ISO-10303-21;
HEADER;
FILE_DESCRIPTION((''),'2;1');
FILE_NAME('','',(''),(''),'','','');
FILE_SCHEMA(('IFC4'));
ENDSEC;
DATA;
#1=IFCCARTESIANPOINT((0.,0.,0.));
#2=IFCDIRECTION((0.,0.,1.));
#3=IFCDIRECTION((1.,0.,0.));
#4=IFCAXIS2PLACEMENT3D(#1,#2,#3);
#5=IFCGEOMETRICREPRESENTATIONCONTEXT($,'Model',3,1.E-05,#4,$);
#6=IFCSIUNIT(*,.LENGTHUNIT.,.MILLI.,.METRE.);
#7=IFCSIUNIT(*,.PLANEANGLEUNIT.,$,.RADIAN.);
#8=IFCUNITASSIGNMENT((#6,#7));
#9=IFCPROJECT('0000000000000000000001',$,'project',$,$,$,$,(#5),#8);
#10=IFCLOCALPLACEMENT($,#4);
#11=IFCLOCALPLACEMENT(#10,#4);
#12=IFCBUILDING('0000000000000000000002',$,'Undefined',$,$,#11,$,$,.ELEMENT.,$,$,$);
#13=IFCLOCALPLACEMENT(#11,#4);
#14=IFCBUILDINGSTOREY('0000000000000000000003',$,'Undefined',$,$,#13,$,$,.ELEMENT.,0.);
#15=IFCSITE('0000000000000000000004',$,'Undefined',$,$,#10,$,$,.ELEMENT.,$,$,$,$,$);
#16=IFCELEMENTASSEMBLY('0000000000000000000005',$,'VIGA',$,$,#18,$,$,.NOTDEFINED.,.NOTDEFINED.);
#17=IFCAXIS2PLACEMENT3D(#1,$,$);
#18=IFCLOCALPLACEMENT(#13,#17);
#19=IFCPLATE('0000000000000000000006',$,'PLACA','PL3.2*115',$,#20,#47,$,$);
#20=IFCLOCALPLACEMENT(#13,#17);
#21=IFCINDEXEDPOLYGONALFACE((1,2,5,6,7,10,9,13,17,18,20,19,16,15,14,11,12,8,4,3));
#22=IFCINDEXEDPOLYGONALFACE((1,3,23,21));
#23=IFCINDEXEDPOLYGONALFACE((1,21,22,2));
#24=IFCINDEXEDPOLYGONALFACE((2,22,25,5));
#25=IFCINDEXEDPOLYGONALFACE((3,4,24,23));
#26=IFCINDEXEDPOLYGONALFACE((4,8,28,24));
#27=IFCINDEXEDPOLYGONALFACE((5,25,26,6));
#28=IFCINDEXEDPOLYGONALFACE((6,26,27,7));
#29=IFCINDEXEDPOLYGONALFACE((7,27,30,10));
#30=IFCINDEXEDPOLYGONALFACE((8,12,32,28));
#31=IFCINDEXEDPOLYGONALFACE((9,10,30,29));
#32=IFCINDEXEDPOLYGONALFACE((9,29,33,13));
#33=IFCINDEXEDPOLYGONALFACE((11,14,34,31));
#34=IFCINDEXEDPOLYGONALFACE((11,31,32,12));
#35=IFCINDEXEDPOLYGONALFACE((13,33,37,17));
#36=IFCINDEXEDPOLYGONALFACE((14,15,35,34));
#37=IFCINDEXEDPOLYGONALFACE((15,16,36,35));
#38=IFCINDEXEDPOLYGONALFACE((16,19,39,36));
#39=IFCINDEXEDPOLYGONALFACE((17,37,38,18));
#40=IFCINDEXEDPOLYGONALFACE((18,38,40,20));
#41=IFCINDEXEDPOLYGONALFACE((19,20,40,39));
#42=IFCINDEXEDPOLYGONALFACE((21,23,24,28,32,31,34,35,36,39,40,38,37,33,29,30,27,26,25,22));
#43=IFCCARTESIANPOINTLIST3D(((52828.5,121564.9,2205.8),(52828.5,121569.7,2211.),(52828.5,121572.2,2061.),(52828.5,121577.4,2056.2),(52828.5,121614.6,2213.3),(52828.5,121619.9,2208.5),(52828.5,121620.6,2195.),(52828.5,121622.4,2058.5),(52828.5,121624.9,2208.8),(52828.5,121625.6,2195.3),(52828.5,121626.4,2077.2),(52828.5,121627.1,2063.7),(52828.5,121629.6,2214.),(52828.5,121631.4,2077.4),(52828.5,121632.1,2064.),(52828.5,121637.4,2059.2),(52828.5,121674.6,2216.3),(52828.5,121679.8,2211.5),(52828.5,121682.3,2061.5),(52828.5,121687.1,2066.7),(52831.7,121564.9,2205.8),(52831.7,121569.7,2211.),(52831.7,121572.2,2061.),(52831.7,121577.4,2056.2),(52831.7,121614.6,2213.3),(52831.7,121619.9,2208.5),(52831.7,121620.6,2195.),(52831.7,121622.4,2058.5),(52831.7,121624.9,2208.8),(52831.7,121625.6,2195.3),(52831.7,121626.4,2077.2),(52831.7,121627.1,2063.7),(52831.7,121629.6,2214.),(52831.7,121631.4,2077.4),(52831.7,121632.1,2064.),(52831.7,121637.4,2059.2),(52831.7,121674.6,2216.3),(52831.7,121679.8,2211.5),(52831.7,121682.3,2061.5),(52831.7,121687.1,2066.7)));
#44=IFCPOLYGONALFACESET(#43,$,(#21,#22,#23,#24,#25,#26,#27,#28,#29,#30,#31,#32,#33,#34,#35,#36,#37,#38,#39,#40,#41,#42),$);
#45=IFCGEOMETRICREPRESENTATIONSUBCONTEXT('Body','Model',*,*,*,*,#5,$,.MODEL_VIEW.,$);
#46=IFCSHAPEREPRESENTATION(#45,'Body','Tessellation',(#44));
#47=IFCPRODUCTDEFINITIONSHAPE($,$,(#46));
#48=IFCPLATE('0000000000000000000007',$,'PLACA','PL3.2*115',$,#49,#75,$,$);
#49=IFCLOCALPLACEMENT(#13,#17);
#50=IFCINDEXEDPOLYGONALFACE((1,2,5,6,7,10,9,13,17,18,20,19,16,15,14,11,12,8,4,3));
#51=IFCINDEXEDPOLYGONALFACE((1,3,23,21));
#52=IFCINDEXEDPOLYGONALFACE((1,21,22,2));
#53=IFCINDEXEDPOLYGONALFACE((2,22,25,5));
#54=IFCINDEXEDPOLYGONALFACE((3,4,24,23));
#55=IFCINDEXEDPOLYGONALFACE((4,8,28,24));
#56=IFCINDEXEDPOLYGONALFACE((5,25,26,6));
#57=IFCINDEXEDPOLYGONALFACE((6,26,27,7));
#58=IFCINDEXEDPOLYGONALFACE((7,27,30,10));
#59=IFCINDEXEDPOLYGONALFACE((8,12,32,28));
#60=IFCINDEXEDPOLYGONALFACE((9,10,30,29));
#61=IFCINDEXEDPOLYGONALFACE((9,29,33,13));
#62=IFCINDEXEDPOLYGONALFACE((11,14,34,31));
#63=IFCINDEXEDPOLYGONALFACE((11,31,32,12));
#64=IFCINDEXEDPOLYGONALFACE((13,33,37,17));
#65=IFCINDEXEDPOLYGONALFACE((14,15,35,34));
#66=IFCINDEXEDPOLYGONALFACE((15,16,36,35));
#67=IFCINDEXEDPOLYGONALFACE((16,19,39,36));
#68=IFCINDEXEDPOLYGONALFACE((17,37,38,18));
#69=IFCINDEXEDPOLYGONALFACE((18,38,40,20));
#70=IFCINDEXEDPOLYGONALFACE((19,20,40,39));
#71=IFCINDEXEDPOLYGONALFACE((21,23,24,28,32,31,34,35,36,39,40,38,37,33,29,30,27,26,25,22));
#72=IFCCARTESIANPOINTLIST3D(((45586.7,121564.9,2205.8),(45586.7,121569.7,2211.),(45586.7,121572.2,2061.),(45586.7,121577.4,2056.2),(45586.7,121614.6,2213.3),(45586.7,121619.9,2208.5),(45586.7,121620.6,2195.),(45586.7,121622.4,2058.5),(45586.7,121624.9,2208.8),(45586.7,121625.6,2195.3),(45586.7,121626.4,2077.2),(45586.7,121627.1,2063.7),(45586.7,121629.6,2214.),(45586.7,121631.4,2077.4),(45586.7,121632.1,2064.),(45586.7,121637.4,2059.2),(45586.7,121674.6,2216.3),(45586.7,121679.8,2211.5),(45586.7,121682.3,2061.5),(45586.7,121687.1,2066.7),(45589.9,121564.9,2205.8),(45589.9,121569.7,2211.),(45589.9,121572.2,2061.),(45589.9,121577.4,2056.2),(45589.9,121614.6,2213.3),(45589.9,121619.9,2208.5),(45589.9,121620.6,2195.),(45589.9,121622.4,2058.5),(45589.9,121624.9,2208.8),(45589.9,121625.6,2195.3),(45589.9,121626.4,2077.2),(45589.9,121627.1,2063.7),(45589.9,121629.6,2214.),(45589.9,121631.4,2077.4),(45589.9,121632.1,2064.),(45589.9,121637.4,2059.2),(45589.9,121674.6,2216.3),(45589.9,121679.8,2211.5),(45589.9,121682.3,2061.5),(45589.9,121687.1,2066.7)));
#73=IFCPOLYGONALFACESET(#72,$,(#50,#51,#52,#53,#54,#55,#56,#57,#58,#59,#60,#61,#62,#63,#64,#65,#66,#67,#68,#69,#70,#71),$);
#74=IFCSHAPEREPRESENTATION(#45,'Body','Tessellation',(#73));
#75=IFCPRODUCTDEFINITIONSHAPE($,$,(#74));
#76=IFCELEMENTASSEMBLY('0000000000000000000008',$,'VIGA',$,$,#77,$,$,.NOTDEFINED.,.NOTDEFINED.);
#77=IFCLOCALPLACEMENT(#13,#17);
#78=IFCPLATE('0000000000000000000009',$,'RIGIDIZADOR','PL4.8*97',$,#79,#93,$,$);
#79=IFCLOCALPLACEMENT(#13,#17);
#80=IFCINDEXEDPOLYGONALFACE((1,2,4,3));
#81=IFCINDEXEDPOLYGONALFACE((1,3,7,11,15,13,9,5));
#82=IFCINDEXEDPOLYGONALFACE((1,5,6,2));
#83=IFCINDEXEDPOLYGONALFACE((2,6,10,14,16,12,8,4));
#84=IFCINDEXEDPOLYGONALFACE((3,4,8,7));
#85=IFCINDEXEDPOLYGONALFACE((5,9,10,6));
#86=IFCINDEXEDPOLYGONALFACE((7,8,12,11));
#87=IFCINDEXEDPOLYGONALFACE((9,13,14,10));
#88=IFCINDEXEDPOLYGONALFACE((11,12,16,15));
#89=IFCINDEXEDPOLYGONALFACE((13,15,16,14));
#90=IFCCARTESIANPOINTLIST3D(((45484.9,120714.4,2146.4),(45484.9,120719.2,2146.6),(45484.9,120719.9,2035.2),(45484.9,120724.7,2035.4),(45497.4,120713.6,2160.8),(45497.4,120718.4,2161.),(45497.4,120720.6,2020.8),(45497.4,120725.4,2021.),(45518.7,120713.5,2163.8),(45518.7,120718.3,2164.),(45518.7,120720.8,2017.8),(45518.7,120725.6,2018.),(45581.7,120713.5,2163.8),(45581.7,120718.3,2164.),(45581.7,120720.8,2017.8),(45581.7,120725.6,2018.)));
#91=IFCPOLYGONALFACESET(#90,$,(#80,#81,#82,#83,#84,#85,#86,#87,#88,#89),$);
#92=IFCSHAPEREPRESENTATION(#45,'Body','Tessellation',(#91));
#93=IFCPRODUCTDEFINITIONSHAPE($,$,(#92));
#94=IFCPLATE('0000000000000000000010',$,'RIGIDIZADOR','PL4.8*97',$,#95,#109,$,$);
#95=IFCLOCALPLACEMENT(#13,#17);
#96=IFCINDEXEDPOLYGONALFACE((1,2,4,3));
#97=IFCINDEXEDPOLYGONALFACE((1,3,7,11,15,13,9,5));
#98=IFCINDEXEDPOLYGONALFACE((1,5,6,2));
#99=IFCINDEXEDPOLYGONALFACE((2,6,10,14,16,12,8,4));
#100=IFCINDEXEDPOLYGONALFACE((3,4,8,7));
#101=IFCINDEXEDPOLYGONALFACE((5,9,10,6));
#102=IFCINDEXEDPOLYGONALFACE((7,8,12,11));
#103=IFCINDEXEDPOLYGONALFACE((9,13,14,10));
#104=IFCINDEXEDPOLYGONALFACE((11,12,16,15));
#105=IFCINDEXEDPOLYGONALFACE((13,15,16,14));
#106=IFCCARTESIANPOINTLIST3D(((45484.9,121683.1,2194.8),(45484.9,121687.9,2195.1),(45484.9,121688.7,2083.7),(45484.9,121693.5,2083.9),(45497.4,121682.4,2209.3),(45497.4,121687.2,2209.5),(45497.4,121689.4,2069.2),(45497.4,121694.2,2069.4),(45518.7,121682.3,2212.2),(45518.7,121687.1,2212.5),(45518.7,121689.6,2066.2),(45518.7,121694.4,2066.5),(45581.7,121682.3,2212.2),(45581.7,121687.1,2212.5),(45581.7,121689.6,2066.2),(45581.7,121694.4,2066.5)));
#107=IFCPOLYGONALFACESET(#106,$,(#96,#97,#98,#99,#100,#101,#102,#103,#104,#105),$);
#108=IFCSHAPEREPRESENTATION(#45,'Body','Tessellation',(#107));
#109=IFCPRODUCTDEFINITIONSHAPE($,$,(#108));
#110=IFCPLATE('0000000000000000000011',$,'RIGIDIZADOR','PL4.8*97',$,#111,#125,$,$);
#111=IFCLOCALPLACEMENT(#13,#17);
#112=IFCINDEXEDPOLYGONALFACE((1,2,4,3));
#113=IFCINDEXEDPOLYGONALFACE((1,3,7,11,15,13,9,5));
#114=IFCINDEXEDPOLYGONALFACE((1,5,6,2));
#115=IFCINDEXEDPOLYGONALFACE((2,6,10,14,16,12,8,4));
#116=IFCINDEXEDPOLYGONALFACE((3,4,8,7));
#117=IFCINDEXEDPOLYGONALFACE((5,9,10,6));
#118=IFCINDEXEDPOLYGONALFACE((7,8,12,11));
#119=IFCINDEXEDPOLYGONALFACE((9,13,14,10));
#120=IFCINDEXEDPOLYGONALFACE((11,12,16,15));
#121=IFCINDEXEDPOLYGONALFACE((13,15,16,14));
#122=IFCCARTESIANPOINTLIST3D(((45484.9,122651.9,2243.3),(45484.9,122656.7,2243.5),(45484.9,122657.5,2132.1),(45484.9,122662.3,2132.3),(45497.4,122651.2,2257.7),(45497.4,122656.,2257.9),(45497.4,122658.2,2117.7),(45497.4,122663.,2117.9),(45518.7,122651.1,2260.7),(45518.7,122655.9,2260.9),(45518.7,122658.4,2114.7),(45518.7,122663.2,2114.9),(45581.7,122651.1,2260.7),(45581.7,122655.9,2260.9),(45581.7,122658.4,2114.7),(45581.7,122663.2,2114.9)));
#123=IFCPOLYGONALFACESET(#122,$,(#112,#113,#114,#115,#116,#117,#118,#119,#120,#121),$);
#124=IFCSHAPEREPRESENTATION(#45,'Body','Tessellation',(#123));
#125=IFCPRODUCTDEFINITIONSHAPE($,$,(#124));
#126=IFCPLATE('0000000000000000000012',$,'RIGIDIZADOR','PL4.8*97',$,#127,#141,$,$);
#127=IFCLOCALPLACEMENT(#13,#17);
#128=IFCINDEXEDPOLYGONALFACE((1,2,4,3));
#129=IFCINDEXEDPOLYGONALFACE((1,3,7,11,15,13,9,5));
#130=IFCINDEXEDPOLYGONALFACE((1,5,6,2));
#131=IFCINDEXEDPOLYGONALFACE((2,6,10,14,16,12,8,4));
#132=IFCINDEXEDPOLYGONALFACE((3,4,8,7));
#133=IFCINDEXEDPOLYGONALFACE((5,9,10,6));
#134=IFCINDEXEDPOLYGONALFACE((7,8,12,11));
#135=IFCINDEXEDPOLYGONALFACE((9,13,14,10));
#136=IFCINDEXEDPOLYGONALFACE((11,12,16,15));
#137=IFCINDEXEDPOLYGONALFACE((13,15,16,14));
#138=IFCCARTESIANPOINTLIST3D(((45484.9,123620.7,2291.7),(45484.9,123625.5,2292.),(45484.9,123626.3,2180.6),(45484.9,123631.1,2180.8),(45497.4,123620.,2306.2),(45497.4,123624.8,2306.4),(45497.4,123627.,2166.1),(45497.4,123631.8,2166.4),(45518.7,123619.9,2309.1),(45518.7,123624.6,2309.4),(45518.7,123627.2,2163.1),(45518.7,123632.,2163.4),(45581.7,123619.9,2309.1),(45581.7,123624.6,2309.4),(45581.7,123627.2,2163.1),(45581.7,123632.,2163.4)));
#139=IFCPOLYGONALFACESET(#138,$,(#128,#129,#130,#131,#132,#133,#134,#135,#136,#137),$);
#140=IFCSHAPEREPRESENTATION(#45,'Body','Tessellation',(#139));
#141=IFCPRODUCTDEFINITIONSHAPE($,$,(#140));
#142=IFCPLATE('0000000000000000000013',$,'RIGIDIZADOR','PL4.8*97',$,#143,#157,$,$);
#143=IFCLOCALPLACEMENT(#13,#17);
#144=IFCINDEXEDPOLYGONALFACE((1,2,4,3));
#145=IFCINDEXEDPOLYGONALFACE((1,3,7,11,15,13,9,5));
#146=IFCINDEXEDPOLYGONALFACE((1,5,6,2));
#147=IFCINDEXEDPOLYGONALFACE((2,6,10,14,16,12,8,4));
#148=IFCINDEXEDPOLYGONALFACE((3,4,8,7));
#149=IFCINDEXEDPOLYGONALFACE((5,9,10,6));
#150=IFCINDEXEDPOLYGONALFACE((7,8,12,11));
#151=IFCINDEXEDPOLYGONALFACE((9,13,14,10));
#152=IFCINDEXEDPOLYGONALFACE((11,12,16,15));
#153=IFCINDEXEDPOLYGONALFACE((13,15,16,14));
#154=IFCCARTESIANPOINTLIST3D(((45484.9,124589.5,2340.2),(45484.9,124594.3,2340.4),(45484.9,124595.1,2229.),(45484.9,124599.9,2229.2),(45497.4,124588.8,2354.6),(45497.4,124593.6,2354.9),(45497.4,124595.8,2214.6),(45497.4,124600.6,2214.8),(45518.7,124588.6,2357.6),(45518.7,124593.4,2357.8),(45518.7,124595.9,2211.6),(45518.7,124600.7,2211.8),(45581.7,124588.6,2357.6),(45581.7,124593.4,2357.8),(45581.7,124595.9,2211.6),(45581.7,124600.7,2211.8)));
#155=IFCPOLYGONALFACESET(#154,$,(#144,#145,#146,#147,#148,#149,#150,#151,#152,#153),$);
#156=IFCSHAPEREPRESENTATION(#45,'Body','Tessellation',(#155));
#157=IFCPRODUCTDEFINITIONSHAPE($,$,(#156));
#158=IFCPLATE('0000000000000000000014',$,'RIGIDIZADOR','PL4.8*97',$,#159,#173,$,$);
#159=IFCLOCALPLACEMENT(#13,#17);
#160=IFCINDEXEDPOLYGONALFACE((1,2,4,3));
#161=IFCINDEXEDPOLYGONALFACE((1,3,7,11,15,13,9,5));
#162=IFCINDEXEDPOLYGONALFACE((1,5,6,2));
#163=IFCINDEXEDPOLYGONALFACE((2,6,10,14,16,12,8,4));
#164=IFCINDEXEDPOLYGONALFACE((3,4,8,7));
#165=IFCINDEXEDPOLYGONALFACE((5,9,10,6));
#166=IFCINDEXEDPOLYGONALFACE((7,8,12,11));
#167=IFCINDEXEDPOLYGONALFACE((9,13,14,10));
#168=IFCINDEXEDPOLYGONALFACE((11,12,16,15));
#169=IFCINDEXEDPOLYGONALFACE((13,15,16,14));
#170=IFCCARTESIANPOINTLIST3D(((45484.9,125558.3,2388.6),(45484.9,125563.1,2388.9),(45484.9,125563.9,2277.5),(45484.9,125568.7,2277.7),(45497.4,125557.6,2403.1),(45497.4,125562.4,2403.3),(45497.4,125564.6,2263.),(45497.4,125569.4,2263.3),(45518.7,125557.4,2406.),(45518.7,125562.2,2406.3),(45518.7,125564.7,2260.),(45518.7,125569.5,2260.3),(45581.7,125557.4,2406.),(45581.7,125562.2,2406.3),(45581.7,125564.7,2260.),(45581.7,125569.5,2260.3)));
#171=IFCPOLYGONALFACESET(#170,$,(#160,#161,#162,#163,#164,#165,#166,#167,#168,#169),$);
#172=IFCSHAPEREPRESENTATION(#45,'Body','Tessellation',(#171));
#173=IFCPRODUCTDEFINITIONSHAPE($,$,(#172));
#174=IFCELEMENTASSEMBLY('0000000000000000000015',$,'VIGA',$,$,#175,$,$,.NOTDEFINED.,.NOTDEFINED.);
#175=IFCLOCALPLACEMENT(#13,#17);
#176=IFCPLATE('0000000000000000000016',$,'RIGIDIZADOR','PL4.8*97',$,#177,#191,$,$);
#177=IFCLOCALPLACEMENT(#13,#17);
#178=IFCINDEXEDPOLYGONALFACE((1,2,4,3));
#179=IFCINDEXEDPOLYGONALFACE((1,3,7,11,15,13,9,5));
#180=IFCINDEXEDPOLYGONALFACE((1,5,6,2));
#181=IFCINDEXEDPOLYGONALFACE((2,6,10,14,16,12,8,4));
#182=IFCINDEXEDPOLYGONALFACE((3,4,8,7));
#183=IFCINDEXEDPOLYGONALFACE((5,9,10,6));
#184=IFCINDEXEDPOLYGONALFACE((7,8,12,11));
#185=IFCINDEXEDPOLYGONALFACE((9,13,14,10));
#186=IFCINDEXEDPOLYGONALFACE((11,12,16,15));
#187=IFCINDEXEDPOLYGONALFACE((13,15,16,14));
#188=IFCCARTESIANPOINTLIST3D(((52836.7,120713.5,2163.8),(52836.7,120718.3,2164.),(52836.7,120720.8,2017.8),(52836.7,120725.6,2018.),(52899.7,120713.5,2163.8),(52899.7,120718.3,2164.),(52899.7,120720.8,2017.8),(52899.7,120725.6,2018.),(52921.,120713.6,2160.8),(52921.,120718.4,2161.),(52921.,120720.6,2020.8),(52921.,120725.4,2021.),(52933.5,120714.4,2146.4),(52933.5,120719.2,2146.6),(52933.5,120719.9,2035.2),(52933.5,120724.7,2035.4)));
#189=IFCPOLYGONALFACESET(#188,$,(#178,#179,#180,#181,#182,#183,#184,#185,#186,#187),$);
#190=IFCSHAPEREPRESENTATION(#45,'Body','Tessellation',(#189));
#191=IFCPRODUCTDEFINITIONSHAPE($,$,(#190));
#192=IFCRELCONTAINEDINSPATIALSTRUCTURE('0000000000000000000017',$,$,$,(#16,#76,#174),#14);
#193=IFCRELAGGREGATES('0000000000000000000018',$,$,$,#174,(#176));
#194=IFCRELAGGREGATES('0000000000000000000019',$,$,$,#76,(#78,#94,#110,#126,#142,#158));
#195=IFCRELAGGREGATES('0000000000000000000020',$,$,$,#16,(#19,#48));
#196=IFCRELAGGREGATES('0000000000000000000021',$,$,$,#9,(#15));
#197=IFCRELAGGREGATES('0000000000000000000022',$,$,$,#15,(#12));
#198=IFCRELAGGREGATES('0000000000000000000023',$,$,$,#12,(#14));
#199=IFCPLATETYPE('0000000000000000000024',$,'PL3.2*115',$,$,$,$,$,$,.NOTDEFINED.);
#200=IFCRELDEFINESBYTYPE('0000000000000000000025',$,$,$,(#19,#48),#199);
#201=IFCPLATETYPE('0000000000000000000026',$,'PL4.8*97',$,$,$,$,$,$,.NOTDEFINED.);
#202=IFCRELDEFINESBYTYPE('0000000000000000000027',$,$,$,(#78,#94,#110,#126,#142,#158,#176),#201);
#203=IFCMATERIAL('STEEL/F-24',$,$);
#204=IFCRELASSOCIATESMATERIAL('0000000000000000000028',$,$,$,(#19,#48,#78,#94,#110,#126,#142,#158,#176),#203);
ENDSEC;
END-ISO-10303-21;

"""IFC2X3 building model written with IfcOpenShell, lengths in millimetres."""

from ifc_helpers import new_model, si_unit, frame, origin_with_axes, place, context, subcontext, project, spatial, polyline, outline, extrude, material, type_object, element, aggregate, save


model = new_model("IFC2X3")

# Units and contexts
model_context = context("Model", 3, precision=1e-05, world=origin_with_axes())
body_context = subcontext(model_context, "Body", "Model", "MODEL_VIEW")
ifc_project = project(units=[si_unit("LENGTHUNIT", "METRE", prefix="MILLI"), si_unit("PLANEANGLEUNIT", "RADIAN")], contexts=[model_context])

# Site, building, storey
site_placement = place(None, origin_with_axes())
site = spatial("IfcSite", under=ifc_project, at=site_placement, Name="Undefined", CompositionType="ELEMENT")
building_placement = place(site_placement, origin_with_axes())
building = spatial("IfcBuilding", under=site, at=building_placement, Name="Undefined", CompositionType="ELEMENT")
storey_placement = place(building_placement, origin_with_axes())
storey = spatial("IfcBuildingStorey", under=building, at=storey_placement, Name="Undefined", CompositionType="ELEMENT", Elevation=0.0)

# Element assemblies, plates
ifc_material_1 = material(Name="STEEL/F-24")
plate_type_1 = type_object("IfcPlateType", Name="PL3.2*115", PredefinedType="NOTDEFINED")
assembly_1_placement = place(storey_placement, origin_with_axes())
assembly_1 = element("IfcElementAssembly", 1, at=assembly_1_placement, inside=storey, Name="VIGA", AssemblyPlace="NOTDEFINED", PredefinedType="NOTDEFINED")
plate_1_placement = place(assembly_1_placement, frame((52830.1, 121564.7, 2210.8), z_axis=(-1.0, 0.0, 0.0), x_axis=(0.0, 0.998752, 0.04995)))
plate_1 = element("IfcPlate", 2, at=plate_1_placement, type_object=plate_type_1, material=ifc_material_1, Name="PLACA", Description="PL3.2*115", context=body_context, shape_type="SweptSolid", body=[
    extrude(outline(polyline([(0.0, 5.0), (5.0, 0.0), (50.0, 0.0), (55.0, 5.0), (55.0, 18.5), (60.0, 18.5), (60.0, 5.0), (65.0, 0.0), (110.0, 0.0), (115.0, 5.0), (115.0, 150.0), (110.0, 155.0), (65.0, 155.0), (60.0, 150.0), (60.0, 136.5), (55.0, 136.5), (55.0, 150.0), (50.0, 155.0), (5.0, 155.0), (0.0, 150.0), (0.0, 5.0)])), frame((0.0, 0.0, -1.6), z_axis=(0.0, 0.0, 1.0), x_axis=(1.0, 0.0, 0.0)), (0.0, 0.0, 1.0), 3.2),
])
plate_2_placement = place(assembly_1_placement, frame((45588.3, 121564.7, 2210.8), z_axis=(-1.0, 0.0, 0.0), x_axis=(0.0, 0.998752, 0.04995)))
plate_2 = element("IfcPlate", 3, at=plate_2_placement, type_object=plate_type_1, material=ifc_material_1, Name="PLACA", Description="PL3.2*115", context=body_context, shape_type="SweptSolid", body=[
    extrude(outline(polyline([(0.0, 5.0), (5.0, 0.0), (50.0, 0.0), (55.0, 5.0), (55.0, 18.5), (60.0, 18.5), (60.0, 5.0), (65.0, 0.0), (110.0, 0.0), (115.0, 5.0), (115.0, 150.0), (110.0, 155.0), (65.0, 155.0), (60.0, 150.0), (60.0, 136.5), (55.0, 136.5), (55.0, 150.0), (50.0, 155.0), (5.0, 155.0), (0.0, 150.0), (0.0, 5.0)])), frame((0.0, 0.0, -1.6), z_axis=(0.0, 0.0, 1.0), x_axis=(1.0, 0.0, 0.0)), (0.0, 0.0, 1.0), 3.2),
])
assembly_2_placement = place(storey_placement, origin_with_axes())
assembly_2 = element("IfcElementAssembly", 4, at=assembly_2_placement, inside=storey, Name="VIGA", AssemblyPlace="NOTDEFINED", PredefinedType="NOTDEFINED")
plate_type_2 = type_object("IfcPlateType", Name="PL4.8*97", PredefinedType="NOTDEFINED")
plate_3_placement = place(assembly_2_placement, frame((45581.7, 120715.9, 2163.9), z_axis=(0.0, -0.998752, -0.04995), x_axis=(-1.0, 0.0, 0.0)))
plate_3 = element("IfcPlate", 5, at=plate_3_placement, type_object=plate_type_2, material=ifc_material_1, Name="RIGIDIZADOR", Description="PL4.8*97", context=body_context, shape_type="SweptSolid", body=[
    extrude(outline(polyline([(0.0, 0.0), (63.0, 0.0), (84.3, 3.0), (96.8, 17.4), (96.8, 128.7), (84.3, 143.2), (63.0, 146.2), (0.0, 146.2), (0.0, 0.0)])), frame((0.0, 0.0, -2.4), z_axis=(0.0, 0.0, 1.0), x_axis=(1.0, 0.0, 0.0)), (0.0, 0.0, 1.0), 4.8),
])
plate_4_placement = place(assembly_2_placement, frame((45581.7, 121684.7, 2212.4), z_axis=(0.0, -0.998752, -0.04995), x_axis=(-1.0, 0.0, 0.0)))
plate_4 = element("IfcPlate", 6, at=plate_4_placement, type_object=plate_type_2, material=ifc_material_1, Name="RIGIDIZADOR", Description="PL4.8*97", context=body_context, shape_type="SweptSolid", body=[
    extrude(outline(polyline([(0.0, 0.0), (63.0, 0.0), (84.3, 3.0), (96.8, 17.4), (96.8, 128.7), (84.3, 143.2), (63.0, 146.2), (0.0, 146.2), (0.0, 0.0)])), frame((0.0, 0.0, -2.4), z_axis=(0.0, 0.0, 1.0), x_axis=(1.0, 0.0, 0.0)), (0.0, 0.0, 1.0), 4.8),
])
plate_5_placement = place(assembly_2_placement, frame((45581.7, 122653.5, 2260.8), z_axis=(0.0, -0.998752, -0.04995), x_axis=(-1.0, 0.0, 0.0)))
plate_5 = element("IfcPlate", 7, at=plate_5_placement, type_object=plate_type_2, material=ifc_material_1, Name="RIGIDIZADOR", Description="PL4.8*97", context=body_context, shape_type="SweptSolid", body=[
    extrude(outline(polyline([(0.0, 0.0), (63.0, 0.0), (84.3, 3.0), (96.8, 17.4), (96.8, 128.7), (84.3, 143.2), (63.0, 146.2), (0.0, 146.2), (0.0, 0.0)])), frame((0.0, 0.0, -2.4), z_axis=(0.0, 0.0, 1.0), x_axis=(1.0, 0.0, 0.0)), (0.0, 0.0, 1.0), 4.8),
])
plate_6_placement = place(assembly_2_placement, frame((45581.7, 123622.3, 2309.3), z_axis=(0.0, -0.998752, -0.04995), x_axis=(-1.0, 0.0, 0.0)))
plate_6 = element("IfcPlate", 8, at=plate_6_placement, type_object=plate_type_2, material=ifc_material_1, Name="RIGIDIZADOR", Description="PL4.8*97", context=body_context, shape_type="SweptSolid", body=[
    extrude(outline(polyline([(0.0, 0.0), (63.0, 0.0), (84.3, 3.0), (96.8, 17.4), (96.8, 128.7), (84.3, 143.2), (63.0, 146.2), (0.0, 146.2), (0.0, 0.0)])), frame((0.0, 0.0, -2.4), z_axis=(0.0, 0.0, 1.0), x_axis=(1.0, 0.0, 0.0)), (0.0, 0.0, 1.0), 4.8),
])
plate_7_placement = place(assembly_2_placement, frame((45581.7, 124591.0, 2357.7), z_axis=(0.0, -0.998752, -0.04995), x_axis=(-1.0, 0.0, 0.0)))
plate_7 = element("IfcPlate", 9, at=plate_7_placement, type_object=plate_type_2, material=ifc_material_1, Name="RIGIDIZADOR", Description="PL4.8*97", context=body_context, shape_type="SweptSolid", body=[
    extrude(outline(polyline([(0.0, 0.0), (63.0, 0.0), (84.3, 3.0), (96.8, 17.4), (96.8, 128.7), (84.3, 143.2), (63.0, 146.2), (0.0, 146.2), (0.0, 0.0)])), frame((0.0, 0.0, -2.4), z_axis=(0.0, 0.0, 1.0), x_axis=(1.0, 0.0, 0.0)), (0.0, 0.0, 1.0), 4.8),
])
plate_8_placement = place(assembly_2_placement, frame((45581.7, 125559.8, 2406.2), z_axis=(0.0, -0.998752, -0.04995), x_axis=(-1.0, 0.0, 0.0)))
plate_8 = element("IfcPlate", 10, at=plate_8_placement, type_object=plate_type_2, material=ifc_material_1, Name="RIGIDIZADOR", Description="PL4.8*97", context=body_context, shape_type="SweptSolid", body=[
    extrude(outline(polyline([(0.0, 0.0), (63.0, 0.0), (84.3, 3.0), (96.8, 17.4), (96.8, 128.7), (84.3, 143.2), (63.0, 146.2), (0.0, 146.2), (0.0, 0.0)])), frame((0.0, 0.0, -2.4), z_axis=(0.0, 0.0, 1.0), x_axis=(1.0, 0.0, 0.0)), (0.0, 0.0, 1.0), 4.8),
])

# Element assembly, plate
assembly_3_placement = place(storey_placement, origin_with_axes())
assembly_3 = element("IfcElementAssembly", 11, at=assembly_3_placement, inside=storey, Name="VIGA", AssemblyPlace="NOTDEFINED", PredefinedType="NOTDEFINED")
plate_9_placement = place(assembly_3_placement, frame((52836.7, 120715.9, 2163.9), z_axis=(0.0, 0.998752, 0.04995), x_axis=(1.0, 0.0, 0.0)))
plate_9 = element("IfcPlate", 12, at=plate_9_placement, type_object=plate_type_2, material=ifc_material_1, Name="RIGIDIZADOR", Description="PL4.8*97", context=body_context, shape_type="SweptSolid", body=[
    extrude(outline(polyline([(0.0, 0.0), (63.0, 0.0), (84.3, 3.0), (96.8, 17.4), (96.8, 128.7), (84.3, 143.2), (63.0, 146.2), (0.0, 146.2), (0.0, 0.0)])), frame((0.0, 0.0, -2.4), z_axis=(0.0, 0.0, 1.0), x_axis=(1.0, 0.0, 0.0)), (0.0, 0.0, 1.0), 4.8),
])
aggregate(assembly_3, [plate_9])

aggregate(assembly_2, [plate_3, plate_4, plate_5, plate_6, plate_7, plate_8])

aggregate(assembly_1, [plate_1, plate_2])

save(model, "model.ifc")
